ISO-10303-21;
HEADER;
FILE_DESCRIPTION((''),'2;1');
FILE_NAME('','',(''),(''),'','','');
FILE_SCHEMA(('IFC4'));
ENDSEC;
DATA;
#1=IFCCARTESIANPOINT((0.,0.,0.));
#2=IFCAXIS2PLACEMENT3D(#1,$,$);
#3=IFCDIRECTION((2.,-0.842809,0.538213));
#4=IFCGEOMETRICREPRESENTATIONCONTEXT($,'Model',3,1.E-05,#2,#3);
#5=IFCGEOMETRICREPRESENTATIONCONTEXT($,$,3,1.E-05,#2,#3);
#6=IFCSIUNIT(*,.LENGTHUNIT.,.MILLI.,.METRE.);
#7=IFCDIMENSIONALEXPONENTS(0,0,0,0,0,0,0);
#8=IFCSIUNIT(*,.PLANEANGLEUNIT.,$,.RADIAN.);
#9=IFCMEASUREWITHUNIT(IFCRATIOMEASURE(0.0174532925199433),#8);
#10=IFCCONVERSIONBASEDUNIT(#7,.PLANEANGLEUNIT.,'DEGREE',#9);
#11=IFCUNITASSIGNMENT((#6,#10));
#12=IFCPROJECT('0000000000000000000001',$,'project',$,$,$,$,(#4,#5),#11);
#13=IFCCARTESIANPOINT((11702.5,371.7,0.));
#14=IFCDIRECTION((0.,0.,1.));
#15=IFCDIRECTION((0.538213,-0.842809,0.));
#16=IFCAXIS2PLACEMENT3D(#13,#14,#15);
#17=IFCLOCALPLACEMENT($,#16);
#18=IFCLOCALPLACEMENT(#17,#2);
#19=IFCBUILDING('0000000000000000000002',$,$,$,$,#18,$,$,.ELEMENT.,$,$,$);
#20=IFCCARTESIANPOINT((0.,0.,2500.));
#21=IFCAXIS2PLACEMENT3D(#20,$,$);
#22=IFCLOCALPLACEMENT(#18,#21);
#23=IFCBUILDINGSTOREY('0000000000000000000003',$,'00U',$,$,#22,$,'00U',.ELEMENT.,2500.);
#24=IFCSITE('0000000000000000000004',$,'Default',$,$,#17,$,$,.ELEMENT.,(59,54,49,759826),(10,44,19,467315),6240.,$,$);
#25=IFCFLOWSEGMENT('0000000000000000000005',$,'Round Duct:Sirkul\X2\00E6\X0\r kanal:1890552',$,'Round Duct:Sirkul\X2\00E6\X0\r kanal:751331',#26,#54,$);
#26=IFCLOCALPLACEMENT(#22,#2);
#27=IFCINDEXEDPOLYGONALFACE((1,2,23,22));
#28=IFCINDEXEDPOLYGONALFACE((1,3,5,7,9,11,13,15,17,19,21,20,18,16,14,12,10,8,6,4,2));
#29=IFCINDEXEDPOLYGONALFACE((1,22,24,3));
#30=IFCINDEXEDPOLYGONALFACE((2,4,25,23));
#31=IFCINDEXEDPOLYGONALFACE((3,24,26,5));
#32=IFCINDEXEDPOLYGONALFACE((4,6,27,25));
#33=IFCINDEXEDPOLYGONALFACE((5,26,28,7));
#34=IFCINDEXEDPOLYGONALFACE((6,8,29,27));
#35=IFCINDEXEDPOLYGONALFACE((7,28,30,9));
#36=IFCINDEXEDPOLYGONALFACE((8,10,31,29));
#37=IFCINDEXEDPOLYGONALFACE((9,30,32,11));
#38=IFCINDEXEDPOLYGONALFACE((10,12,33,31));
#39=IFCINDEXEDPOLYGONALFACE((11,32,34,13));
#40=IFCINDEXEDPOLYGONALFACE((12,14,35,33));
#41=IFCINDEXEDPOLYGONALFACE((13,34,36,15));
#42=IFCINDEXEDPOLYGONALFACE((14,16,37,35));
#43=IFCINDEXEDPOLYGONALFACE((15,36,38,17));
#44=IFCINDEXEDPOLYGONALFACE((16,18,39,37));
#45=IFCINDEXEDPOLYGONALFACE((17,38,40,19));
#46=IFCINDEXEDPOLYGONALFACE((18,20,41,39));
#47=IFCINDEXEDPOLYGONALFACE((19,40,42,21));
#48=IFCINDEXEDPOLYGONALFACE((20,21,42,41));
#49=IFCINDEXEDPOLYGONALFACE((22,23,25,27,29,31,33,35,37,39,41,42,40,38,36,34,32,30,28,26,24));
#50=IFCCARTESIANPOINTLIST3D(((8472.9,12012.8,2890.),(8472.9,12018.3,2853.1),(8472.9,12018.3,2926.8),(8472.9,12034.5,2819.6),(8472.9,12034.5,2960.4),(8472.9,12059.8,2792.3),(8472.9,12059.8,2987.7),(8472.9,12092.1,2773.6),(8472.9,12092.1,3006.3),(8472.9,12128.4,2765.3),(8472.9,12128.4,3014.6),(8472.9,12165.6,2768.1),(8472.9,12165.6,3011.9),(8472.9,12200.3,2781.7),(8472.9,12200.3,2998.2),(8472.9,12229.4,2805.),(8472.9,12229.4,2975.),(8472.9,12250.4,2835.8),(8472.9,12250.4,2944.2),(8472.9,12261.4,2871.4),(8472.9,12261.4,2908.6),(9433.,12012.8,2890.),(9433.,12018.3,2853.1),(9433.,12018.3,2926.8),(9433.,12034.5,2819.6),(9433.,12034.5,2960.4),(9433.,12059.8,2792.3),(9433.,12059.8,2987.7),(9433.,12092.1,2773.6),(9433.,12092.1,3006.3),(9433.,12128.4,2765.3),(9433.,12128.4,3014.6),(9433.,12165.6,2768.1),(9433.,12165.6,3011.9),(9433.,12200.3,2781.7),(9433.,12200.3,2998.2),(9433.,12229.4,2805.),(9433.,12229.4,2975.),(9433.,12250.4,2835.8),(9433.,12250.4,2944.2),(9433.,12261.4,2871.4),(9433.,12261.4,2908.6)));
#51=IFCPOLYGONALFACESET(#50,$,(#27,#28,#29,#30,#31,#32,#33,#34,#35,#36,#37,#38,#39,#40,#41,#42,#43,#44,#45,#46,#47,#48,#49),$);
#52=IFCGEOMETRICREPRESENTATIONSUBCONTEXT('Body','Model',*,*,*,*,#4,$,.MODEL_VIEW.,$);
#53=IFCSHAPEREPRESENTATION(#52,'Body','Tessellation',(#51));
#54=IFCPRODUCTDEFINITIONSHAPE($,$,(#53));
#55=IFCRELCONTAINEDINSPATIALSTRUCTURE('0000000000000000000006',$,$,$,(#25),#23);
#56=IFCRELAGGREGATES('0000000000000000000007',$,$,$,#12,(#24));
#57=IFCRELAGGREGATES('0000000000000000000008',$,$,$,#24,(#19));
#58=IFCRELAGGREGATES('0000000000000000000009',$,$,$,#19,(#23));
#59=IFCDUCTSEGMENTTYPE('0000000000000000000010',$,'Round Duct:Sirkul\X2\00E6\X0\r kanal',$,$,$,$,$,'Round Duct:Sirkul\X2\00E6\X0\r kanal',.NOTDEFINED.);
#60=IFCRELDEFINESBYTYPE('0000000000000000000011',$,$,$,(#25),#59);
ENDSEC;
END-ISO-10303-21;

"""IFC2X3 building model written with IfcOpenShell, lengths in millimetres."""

from ifc_helpers import new_model, entity, si_unit, converted_unit, direction, frame, origin, origin_2d_with_axis, place, context, subcontext, project, spatial, circle, extrude, type_object, element, save


model = new_model("IFC2X3")

# Units and contexts
model_context = context("Model", 3, precision=1e-05, world=origin(), true_north=direction((2.0, -0.842809, 0.538213)))
context_of_model = context(None, 3, precision=1e-05, world=origin(), true_north=direction((2.0, -0.842809, 0.538213)))
body_context = subcontext(model_context, "Body", "Model", "MODEL_VIEW")
ifc_project = project(units=[si_unit("LENGTHUNIT", "METRE", prefix="MILLI"), converted_unit("PLANEANGLEUNIT", "DEGREE", entity("IfcRatioMeasure", 0.0174532925199433), si_unit("PLANEANGLEUNIT", "RADIAN"), dimensions=[0, 0, 0, 0, 0, 0, 0])], contexts=[model_context, context_of_model])

# Site, building, storey
site_placement = place(None, frame((11702.5, 371.7, 0.0), z_axis=(0.0, 0.0, 1.0), x_axis=(0.538213, -0.842809, 0.0)))
site = spatial("IfcSite", under=ifc_project, at=site_placement, Name="Default", CompositionType="ELEMENT", RefLatitude=(59, 54, 49, 759826), RefLongitude=(10, 44, 19, 467315), RefElevation=6240.0)
building_placement = place(site_placement, origin())
building = spatial("IfcBuilding", under=site, at=building_placement, CompositionType="ELEMENT")
storey_placement = place(building_placement, frame((0.0, 0.0, 2500.0)))
storey = spatial("IfcBuildingStorey", under=building, at=storey_placement, Name="00U", LongName="00U", CompositionType="ELEMENT", Elevation=2500.0)

# Flow segment
duct_segment_type_1 = type_object("IfcDuctSegmentType", Name="Round Duct:Sirkulær kanal", ElementType="Round Duct:Sirkulær kanal", PredefinedType="NOTDEFINED")
flow_segment_1_placement = place(storey_placement, origin())
element("IfcFlowSegment", 1, at=flow_segment_1_placement, inside=storey, type_object=duct_segment_type_1, Name="Round Duct:Sirkulær kanal:1890552", ObjectType="Round Duct:Sirkulær kanal:751331", context=body_context, shape_type="SweptSolid", body=[
    extrude(circle(Radius=125.0, at=origin_2d_with_axis()), frame((8472.9, 12137.8, 2890.0), z_axis=(1.0, 0.0, 0.0), x_axis=(0.0, -1.0, 0.0)), (0.0, 0.0, 1.0), 960.2),
])

save(model, "model.ifc")
